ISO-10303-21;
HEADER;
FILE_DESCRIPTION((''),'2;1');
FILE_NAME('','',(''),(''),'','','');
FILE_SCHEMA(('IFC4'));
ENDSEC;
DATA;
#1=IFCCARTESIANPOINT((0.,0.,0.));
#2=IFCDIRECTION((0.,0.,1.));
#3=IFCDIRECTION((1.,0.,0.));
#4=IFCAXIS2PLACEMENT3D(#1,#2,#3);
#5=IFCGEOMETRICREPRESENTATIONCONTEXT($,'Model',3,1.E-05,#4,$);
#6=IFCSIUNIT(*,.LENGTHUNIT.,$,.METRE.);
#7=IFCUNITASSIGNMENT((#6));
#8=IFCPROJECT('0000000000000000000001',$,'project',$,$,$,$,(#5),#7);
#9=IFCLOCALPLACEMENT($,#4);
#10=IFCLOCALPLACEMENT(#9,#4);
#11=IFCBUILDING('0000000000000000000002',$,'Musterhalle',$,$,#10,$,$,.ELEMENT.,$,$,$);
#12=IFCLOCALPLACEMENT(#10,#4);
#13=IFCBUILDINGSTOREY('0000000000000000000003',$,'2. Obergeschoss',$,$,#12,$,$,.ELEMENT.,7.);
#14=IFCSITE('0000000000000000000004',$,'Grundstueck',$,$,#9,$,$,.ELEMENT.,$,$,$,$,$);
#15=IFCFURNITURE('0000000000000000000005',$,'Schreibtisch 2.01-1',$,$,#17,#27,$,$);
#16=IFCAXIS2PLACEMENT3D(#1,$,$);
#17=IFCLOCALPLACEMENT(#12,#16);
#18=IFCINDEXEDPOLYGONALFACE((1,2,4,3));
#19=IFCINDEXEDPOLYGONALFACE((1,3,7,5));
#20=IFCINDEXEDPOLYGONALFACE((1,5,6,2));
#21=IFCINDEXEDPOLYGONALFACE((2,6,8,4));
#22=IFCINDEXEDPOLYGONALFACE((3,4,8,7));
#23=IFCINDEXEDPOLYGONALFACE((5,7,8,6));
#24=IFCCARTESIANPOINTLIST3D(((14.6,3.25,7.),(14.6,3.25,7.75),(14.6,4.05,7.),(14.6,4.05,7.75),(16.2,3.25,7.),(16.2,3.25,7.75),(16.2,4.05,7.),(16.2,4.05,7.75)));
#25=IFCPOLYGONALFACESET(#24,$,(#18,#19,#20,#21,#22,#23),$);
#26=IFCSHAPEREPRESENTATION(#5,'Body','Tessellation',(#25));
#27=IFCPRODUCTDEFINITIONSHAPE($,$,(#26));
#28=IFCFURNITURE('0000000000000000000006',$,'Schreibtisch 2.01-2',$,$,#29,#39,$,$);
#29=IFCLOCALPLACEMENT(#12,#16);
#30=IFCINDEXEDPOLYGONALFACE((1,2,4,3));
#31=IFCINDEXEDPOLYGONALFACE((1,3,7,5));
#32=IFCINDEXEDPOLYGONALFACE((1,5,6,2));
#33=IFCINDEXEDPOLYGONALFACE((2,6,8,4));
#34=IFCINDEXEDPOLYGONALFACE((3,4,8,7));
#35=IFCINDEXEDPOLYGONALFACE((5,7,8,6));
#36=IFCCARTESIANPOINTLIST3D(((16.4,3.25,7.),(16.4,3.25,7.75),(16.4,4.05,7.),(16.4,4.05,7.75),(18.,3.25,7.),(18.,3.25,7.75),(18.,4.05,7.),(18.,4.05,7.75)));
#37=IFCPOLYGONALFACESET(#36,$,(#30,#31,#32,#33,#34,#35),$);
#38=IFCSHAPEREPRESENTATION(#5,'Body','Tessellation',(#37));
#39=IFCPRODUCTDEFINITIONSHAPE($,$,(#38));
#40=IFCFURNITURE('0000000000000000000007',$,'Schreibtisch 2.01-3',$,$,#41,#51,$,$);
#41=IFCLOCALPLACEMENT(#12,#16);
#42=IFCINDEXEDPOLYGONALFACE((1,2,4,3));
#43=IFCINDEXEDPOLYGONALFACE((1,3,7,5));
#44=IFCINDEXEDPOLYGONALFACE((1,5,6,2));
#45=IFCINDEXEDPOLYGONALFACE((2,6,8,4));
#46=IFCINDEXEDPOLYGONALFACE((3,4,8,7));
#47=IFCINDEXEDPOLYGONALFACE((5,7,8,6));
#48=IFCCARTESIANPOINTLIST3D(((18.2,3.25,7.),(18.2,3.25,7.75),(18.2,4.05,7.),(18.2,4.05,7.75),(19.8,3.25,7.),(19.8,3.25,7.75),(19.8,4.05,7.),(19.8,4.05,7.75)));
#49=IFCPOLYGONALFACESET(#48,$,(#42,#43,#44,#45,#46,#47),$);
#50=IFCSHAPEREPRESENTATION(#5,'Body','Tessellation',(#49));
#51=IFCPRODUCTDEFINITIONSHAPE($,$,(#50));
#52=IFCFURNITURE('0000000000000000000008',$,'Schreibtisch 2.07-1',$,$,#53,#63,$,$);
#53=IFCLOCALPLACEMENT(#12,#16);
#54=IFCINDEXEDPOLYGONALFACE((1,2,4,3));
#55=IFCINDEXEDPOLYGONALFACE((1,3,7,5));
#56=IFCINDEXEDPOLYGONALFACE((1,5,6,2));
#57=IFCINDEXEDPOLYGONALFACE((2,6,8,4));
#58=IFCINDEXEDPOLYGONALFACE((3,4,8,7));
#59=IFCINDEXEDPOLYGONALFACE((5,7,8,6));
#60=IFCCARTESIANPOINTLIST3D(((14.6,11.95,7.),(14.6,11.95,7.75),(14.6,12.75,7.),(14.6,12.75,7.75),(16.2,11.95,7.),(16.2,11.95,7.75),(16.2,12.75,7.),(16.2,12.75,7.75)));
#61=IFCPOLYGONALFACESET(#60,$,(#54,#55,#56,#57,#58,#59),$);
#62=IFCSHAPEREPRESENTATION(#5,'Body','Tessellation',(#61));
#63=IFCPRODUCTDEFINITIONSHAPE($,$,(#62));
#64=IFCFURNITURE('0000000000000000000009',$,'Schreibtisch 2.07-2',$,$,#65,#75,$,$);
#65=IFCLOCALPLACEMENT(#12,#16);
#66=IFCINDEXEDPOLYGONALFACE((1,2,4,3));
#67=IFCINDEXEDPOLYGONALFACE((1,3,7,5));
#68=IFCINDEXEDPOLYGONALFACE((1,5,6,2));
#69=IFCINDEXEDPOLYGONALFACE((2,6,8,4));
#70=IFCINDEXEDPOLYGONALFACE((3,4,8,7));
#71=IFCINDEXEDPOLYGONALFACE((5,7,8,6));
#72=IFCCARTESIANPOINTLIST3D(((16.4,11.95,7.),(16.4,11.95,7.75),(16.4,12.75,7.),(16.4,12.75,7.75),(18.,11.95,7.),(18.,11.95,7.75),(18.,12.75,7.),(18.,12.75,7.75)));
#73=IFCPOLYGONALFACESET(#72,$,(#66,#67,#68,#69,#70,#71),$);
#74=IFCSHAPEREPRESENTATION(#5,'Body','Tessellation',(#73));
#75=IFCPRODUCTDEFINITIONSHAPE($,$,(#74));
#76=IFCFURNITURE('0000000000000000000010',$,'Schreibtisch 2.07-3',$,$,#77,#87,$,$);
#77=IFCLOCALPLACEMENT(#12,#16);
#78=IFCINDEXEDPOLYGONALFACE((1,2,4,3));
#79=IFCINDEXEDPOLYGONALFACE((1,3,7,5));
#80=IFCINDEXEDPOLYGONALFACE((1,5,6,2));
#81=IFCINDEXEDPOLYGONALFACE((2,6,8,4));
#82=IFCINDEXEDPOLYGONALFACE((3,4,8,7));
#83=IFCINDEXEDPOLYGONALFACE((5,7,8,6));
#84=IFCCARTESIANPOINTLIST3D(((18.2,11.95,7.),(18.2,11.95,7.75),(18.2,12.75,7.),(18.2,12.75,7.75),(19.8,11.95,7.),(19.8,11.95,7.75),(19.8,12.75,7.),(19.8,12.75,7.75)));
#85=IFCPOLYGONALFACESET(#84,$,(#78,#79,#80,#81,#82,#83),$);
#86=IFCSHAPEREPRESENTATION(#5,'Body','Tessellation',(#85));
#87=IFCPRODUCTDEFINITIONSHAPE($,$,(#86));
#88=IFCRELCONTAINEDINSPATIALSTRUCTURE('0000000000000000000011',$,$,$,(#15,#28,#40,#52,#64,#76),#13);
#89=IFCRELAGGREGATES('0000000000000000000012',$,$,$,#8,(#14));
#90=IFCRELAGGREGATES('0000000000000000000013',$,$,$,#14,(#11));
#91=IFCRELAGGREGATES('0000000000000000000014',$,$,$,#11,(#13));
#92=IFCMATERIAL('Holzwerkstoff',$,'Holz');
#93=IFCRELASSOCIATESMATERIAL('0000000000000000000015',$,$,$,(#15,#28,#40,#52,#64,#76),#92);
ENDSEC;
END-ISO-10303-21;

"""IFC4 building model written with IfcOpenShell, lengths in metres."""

from ifc_helpers import new_model, si_unit, frame, origin_with_axes, origin_2d, place, context, project, spatial, rectangle, extrude, material, element, save


model = new_model("IFC4")

# Units and contexts
model_context = context("Model", 3, precision=1e-05, world=origin_with_axes())
ifc_project = project(units=[si_unit("LENGTHUNIT", "METRE")], contexts=[model_context])

# Site, building, storey
site_placement = place(None, origin_with_axes())
site = spatial("IfcSite", under=ifc_project, at=site_placement, Name="Grundstueck", CompositionType="ELEMENT")
building_placement = place(site_placement, origin_with_axes())
building = spatial("IfcBuilding", under=site, at=building_placement, Name="Musterhalle", CompositionType="ELEMENT")
storey_placement = place(building_placement, origin_with_axes())
storey = spatial("IfcBuildingStorey", under=building, at=storey_placement, Name="2. Obergeschoss", CompositionType="ELEMENT", Elevation=7.0)

# Shared definitions
placement = place(storey_placement, origin_with_axes())

# Shared definitions
ifc_material_1 = material(Name="Holzwerkstoff", Category="Holz")

# Furniture
element("IfcFurniture", 1, at=placement, inside=storey, material=ifc_material_1, Name="Schreibtisch 2.01-1", context=model_context, shape_type="SweptSolid", body=[
    extrude(rectangle(XDim=1.6, YDim=0.8, at=origin_2d()), frame((15.4, 3.65, 7.0), z_axis=(0.0, 0.0, 1.0), x_axis=(1.0, 0.0, 0.0)), (0.0, 0.0, 1.0), 0.75),
])
element("IfcFurniture", 2, at=placement, inside=storey, material=ifc_material_1, Name="Schreibtisch 2.01-2", context=model_context, shape_type="SweptSolid", body=[
    extrude(rectangle(XDim=1.6, YDim=0.8, at=origin_2d()), frame((17.2, 3.65, 7.0), z_axis=(0.0, 0.0, 1.0), x_axis=(1.0, 0.0, 0.0)), (0.0, 0.0, 1.0), 0.75),
])
element("IfcFurniture", 3, at=placement, inside=storey, material=ifc_material_1, Name="Schreibtisch 2.01-3", context=model_context, shape_type="SweptSolid", body=[
    extrude(rectangle(XDim=1.6, YDim=0.8, at=origin_2d()), frame((19.0, 3.65, 7.0), z_axis=(0.0, 0.0, 1.0), x_axis=(1.0, 0.0, 0.0)), (0.0, 0.0, 1.0), 0.75),
])
element("IfcFurniture", 4, at=placement, inside=storey, material=ifc_material_1, Name="Schreibtisch 2.07-1", context=model_context, shape_type="SweptSolid", body=[
    extrude(rectangle(XDim=1.6, YDim=0.8, at=origin_2d()), frame((15.4, 12.35, 7.0), z_axis=(0.0, 0.0, 1.0), x_axis=(1.0, 0.0, 0.0)), (0.0, 0.0, 1.0), 0.75),
])
element("IfcFurniture", 5, at=placement, inside=storey, material=ifc_material_1, Name="Schreibtisch 2.07-2", context=model_context, shape_type="SweptSolid", body=[
    extrude(rectangle(XDim=1.6, YDim=0.8, at=origin_2d()), frame((17.2, 12.35, 7.0), z_axis=(0.0, 0.0, 1.0), x_axis=(1.0, 0.0, 0.0)), (0.0, 0.0, 1.0), 0.75),
])
element("IfcFurniture", 6, at=placement, inside=storey, material=ifc_material_1, Name="Schreibtisch 2.07-3", context=model_context, shape_type="SweptSolid", body=[
    extrude(rectangle(XDim=1.6, YDim=0.8, at=origin_2d()), frame((19.0, 12.35, 7.0), z_axis=(0.0, 0.0, 1.0), x_axis=(1.0, 0.0, 0.0)), (0.0, 0.0, 1.0), 0.75),
])

save(model, "model.ifc")
